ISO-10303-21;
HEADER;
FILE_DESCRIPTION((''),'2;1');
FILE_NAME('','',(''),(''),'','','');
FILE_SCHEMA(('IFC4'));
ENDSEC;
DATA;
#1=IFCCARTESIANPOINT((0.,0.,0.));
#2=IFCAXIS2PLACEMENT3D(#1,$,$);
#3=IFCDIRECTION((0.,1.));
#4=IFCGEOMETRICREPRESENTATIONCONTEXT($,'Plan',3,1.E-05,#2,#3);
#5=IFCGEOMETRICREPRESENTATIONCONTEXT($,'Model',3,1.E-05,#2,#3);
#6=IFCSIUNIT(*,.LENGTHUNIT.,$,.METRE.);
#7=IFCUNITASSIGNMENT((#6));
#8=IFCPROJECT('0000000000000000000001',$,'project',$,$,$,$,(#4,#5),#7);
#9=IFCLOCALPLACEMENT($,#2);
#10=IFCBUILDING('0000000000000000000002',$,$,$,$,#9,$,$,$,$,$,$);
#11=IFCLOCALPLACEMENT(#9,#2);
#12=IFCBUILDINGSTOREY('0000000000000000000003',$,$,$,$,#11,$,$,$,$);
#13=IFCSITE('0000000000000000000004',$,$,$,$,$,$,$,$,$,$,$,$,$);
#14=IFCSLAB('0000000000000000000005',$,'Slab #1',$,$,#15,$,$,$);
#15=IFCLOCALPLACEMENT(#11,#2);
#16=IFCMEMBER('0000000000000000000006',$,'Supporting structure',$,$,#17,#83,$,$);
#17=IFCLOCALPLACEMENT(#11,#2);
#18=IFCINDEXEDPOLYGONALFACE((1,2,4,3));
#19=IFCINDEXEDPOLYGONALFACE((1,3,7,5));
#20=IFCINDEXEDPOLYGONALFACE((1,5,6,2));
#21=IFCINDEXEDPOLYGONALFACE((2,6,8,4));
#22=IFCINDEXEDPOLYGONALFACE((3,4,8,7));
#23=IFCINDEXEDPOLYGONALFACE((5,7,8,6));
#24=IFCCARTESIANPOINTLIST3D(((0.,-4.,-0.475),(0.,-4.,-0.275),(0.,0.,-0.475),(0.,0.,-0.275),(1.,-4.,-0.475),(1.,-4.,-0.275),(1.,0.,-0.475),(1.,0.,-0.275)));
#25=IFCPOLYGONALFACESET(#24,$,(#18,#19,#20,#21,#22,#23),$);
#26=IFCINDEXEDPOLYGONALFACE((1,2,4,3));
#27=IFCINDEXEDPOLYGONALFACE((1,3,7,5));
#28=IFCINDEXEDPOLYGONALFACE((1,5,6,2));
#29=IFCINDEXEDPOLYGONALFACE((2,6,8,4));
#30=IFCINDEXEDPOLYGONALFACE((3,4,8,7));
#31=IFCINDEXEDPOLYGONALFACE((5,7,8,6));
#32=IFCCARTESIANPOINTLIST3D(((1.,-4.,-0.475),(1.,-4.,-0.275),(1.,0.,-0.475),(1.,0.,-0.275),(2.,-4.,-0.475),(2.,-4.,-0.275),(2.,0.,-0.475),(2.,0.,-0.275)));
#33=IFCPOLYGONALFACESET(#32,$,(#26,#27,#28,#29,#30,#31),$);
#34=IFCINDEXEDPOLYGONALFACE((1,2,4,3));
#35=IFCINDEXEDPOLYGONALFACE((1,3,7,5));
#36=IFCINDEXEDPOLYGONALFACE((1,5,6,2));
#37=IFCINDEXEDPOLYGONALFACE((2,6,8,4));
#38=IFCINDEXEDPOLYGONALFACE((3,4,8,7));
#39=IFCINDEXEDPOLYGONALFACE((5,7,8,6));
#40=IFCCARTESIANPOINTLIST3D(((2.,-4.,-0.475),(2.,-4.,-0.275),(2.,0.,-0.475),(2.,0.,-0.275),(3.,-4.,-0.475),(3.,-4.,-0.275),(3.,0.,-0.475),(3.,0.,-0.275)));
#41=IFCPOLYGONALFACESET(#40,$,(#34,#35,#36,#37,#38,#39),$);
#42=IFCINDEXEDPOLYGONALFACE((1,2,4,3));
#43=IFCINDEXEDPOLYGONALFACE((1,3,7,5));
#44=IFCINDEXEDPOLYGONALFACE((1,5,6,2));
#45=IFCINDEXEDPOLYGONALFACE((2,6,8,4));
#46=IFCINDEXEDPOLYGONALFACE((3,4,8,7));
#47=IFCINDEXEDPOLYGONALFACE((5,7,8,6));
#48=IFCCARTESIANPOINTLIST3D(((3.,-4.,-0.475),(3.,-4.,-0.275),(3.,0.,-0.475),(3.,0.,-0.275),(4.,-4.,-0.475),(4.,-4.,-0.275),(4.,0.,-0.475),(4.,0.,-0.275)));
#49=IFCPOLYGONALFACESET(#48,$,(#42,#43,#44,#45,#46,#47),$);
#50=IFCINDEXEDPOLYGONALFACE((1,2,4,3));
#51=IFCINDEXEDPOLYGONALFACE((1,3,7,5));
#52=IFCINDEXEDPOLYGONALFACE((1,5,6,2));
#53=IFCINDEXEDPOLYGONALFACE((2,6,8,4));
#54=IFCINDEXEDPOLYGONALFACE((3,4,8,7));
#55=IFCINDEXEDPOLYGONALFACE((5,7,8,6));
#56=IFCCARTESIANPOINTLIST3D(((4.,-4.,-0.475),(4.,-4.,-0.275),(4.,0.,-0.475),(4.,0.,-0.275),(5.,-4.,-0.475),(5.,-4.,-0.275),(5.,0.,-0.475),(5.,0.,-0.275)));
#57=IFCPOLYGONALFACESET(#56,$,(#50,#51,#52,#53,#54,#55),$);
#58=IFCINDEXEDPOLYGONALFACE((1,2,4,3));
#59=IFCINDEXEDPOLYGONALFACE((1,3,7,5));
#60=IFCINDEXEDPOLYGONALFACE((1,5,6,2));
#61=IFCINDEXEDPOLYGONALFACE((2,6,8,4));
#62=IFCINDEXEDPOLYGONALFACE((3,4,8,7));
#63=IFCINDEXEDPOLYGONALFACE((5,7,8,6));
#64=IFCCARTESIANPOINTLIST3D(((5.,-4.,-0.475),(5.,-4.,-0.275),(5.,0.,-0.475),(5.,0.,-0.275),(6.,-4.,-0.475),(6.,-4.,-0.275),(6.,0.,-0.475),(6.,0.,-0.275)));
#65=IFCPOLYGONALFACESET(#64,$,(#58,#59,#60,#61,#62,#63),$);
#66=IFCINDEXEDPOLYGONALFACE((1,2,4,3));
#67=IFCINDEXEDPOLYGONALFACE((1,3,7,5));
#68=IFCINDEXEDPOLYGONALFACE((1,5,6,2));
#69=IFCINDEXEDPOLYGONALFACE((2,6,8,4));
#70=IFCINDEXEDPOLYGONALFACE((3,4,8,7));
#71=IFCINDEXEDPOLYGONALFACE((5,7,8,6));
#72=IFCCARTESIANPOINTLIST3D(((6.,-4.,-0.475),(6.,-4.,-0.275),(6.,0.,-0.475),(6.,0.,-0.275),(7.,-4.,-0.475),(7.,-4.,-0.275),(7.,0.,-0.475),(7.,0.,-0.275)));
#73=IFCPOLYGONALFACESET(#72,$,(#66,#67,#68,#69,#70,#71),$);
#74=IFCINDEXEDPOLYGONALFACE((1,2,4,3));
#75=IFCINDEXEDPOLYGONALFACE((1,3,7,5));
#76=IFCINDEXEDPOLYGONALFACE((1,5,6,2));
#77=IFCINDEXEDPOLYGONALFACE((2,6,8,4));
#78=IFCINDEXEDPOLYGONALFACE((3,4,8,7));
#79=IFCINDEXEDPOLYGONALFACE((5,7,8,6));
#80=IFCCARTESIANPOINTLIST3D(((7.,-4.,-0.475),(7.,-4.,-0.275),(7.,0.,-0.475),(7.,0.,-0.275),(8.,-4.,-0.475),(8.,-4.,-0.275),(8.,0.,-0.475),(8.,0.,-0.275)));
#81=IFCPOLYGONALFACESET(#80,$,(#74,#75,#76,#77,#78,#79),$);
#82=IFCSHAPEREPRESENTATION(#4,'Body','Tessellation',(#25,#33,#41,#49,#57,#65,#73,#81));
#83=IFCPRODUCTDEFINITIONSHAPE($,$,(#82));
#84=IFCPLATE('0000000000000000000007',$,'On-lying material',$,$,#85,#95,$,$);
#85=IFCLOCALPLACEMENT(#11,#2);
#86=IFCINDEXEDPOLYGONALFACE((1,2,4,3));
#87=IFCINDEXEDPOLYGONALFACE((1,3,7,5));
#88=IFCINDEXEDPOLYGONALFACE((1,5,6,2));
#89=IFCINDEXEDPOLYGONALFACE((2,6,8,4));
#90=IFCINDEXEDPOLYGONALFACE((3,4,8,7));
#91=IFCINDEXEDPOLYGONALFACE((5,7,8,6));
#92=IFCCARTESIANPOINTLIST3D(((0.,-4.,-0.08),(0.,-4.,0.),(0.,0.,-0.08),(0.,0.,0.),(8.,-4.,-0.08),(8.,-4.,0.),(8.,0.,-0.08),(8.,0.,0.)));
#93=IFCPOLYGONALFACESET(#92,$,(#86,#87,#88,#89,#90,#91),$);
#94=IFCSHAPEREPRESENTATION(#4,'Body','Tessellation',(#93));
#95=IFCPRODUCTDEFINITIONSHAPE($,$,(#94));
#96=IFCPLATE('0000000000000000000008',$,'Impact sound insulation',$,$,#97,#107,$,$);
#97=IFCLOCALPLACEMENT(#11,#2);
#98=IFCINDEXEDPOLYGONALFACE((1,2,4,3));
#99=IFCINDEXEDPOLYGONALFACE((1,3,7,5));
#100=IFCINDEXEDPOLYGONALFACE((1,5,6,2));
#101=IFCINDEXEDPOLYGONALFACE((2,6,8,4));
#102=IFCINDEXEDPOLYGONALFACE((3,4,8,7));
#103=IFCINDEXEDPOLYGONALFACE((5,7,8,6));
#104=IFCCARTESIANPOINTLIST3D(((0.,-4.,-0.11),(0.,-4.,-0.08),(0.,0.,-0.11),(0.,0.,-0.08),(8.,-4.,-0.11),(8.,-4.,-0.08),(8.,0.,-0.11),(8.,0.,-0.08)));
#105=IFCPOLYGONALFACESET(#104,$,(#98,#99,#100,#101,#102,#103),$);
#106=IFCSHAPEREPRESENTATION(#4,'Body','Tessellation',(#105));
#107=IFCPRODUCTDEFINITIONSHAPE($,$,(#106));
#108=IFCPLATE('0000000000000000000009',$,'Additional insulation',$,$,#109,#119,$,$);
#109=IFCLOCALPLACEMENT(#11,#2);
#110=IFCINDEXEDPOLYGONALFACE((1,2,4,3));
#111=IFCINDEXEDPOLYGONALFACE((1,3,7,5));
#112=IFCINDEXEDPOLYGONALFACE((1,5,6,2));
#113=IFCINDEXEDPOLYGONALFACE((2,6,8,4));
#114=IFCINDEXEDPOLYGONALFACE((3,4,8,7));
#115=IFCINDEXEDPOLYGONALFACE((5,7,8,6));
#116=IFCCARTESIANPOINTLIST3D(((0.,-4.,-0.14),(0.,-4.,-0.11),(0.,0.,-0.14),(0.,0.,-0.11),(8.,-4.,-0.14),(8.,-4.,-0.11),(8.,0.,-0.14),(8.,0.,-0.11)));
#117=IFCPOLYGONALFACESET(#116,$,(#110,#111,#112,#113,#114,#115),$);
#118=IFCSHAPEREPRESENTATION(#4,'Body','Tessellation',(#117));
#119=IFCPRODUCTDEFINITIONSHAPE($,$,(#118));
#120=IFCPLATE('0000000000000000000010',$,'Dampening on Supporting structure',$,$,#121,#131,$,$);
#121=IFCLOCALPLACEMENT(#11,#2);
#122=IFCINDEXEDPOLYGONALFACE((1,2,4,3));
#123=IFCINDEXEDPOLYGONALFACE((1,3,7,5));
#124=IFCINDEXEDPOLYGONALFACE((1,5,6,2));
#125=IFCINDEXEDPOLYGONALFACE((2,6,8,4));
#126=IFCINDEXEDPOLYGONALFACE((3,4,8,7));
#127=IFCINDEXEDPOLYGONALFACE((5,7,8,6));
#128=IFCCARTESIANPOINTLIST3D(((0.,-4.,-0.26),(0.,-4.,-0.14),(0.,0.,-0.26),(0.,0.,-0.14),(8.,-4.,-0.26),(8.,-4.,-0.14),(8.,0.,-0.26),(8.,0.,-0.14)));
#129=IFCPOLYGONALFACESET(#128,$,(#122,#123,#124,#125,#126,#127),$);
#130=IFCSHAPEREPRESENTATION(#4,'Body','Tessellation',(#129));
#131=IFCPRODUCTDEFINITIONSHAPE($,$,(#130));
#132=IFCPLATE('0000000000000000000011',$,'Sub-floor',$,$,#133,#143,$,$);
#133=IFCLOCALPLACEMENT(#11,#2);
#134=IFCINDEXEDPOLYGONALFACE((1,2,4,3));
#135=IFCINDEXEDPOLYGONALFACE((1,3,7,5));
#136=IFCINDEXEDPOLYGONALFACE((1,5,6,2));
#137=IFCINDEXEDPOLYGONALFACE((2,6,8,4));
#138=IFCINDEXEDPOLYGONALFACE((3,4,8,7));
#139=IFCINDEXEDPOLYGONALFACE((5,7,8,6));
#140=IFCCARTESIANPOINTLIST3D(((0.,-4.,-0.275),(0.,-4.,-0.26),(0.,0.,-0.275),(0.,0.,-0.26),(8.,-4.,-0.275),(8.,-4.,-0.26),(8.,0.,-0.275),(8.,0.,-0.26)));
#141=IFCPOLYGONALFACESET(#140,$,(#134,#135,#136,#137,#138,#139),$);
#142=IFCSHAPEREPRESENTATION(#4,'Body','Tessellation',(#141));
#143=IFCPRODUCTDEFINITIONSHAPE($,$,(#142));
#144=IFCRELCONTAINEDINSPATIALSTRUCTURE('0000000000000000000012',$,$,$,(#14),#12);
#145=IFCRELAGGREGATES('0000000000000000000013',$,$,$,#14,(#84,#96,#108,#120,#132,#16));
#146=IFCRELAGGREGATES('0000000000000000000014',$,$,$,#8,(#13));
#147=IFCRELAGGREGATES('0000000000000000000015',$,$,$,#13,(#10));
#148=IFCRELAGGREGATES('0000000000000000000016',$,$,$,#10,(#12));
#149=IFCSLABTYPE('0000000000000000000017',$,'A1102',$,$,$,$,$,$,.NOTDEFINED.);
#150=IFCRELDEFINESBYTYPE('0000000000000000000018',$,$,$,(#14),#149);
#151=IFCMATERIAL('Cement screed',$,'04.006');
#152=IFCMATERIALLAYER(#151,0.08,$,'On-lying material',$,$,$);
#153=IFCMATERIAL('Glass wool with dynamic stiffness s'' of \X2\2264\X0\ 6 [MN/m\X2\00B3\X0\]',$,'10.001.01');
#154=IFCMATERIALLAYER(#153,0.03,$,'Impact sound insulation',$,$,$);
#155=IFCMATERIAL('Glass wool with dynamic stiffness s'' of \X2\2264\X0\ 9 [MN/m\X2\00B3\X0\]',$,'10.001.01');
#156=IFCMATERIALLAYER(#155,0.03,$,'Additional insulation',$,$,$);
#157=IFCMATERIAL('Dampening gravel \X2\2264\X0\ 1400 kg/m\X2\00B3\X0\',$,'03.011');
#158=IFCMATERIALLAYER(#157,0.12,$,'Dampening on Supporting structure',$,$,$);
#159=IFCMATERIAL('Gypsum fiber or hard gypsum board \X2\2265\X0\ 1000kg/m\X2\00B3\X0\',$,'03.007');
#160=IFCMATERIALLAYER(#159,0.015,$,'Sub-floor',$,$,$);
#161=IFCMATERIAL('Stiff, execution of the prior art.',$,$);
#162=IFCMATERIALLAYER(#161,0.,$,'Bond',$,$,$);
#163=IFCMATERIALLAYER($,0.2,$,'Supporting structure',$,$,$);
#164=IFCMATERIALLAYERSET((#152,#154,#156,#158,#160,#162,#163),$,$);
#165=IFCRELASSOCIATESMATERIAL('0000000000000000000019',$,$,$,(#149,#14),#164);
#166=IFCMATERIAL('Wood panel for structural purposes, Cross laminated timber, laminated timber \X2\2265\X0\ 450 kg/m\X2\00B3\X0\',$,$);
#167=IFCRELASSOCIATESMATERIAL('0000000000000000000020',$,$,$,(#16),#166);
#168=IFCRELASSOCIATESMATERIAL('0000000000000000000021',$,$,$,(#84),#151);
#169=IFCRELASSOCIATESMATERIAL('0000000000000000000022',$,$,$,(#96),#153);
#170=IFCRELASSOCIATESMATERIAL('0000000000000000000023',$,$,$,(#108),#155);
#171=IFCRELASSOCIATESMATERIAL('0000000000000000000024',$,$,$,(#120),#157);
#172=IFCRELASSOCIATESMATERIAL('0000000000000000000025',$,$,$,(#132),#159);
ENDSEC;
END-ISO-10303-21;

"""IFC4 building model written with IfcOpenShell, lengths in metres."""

from ifc_helpers import new_model, si_unit, direction, frame, frame_2d, origin, origin_with_axes, place, context, project, spatial, rectangle, extrude, material, layer, layer_set, type_object, element, aggregate, save


model = new_model("IFC4")

# Units and contexts
plan_context = context("Plan", 3, precision=1e-05, world=origin(), true_north=direction((0.0, 1.0)))
model_context = context("Model", 3, precision=1e-05, world=origin(), true_north=direction((0.0, 1.0)))
ifc_project = project(units=[si_unit("LENGTHUNIT", "METRE")], contexts=[plan_context, model_context])

# Site, building, storey
site = spatial("IfcSite", under=ifc_project)
building_placement = place(None, origin())
building = spatial("IfcBuilding", under=site, at=building_placement)
storey_placement = place(building_placement, origin())
storey = spatial("IfcBuildingStorey", under=building, at=storey_placement)

# Slab, member, plates
ifc_material_1 = material(Name="Cement screed", Category="04.006")
ifc_layer_1 = layer(ifc_material_1, 0.08, Name="On-lying material")
ifc_material_2 = material(Name="Glass wool with dynamic stiffness s' of ≤ 6 [MN/m³]", Category="10.001.01")
ifc_layer_2 = layer(ifc_material_2, 0.03, Name="Impact sound insulation")
ifc_material_3 = material(Name="Glass wool with dynamic stiffness s' of ≤ 9 [MN/m³]", Category="10.001.01")
ifc_layer_3 = layer(ifc_material_3, 0.03, Name="Additional insulation")
ifc_material_4 = material(Name="Dampening gravel ≤ 1400 kg/m³", Category="03.011")
ifc_layer_4 = layer(ifc_material_4, 0.12, Name="Dampening on Supporting structure")
ifc_material_5 = material(Name="Gypsum fiber or hard gypsum board ≥ 1000kg/m³", Category="03.007")
ifc_layer_5 = layer(ifc_material_5, 0.015, Name="Sub-floor")
ifc_material_6 = material(Name="Stiff, execution of the prior art.")
ifc_layer_6 = layer(ifc_material_6, 0.0, Name="Bond")
ifc_layer_7 = layer(None, 0.2, Name="Supporting structure")
ifc_layer_set = layer_set([ifc_layer_1, ifc_layer_2, ifc_layer_3, ifc_layer_4, ifc_layer_5, ifc_layer_6, ifc_layer_7])
slab_type = type_object("IfcSlabType", Name="A1102", PredefinedType="NOTDEFINED", material=ifc_layer_set)
slab_placement = place(None, frame((0.0, 0.0, 0.0), z_axis=(0.0, 0.0, -1.0), x_axis=(1.0, 0.0, 0.0)))
slab = element("IfcSlab", 1, at=slab_placement, inside=storey, type_object=slab_type, material=ifc_layer_set, Name="Slab #1")
ifc_material_7 = material(Name="Wood panel for structural purposes, Cross laminated timber, laminated timber ≥ 450 kg/m³")
member_placement = place(slab_placement, origin())
member = element("IfcMember", 2, at=member_placement, material=ifc_material_7, Name="Supporting structure", context=plan_context, shape_type="SweptSolid", body=[
    extrude(rectangle(XDim=1.0, YDim=0.2, at=frame_2d((0.5, 0.1), x_axis=(1.0, 0.0))), frame((0.0, 4.0, 0.275), z_axis=(0.0, -1.0, 0.0), x_axis=(1.0, 0.0, 0.0)), (0.0, 0.0, 1.0), 4.0),
    extrude(rectangle(XDim=1.0, YDim=0.2, at=frame_2d((0.5, 0.1), x_axis=(1.0, 0.0))), frame((1.0, 4.0, 0.275), z_axis=(0.0, -1.0, 0.0), x_axis=(1.0, 0.0, 0.0)), (0.0, 0.0, 1.0), 4.0),
    extrude(rectangle(XDim=1.0, YDim=0.2, at=frame_2d((0.5, 0.1), x_axis=(1.0, 0.0))), frame((2.0, 4.0, 0.275), z_axis=(0.0, -1.0, 0.0), x_axis=(1.0, 0.0, 0.0)), (0.0, 0.0, 1.0), 4.0),
    extrude(rectangle(XDim=1.0, YDim=0.2, at=frame_2d((0.5, 0.1), x_axis=(1.0, 0.0))), frame((3.0, 4.0, 0.275), z_axis=(0.0, -1.0, 0.0), x_axis=(1.0, 0.0, 0.0)), (0.0, 0.0, 1.0), 4.0),
    extrude(rectangle(XDim=1.0, YDim=0.2, at=frame_2d((0.5, 0.1), x_axis=(1.0, 0.0))), frame((4.0, 4.0, 0.275), z_axis=(0.0, -1.0, 0.0), x_axis=(1.0, 0.0, 0.0)), (0.0, 0.0, 1.0), 4.0),
    extrude(rectangle(XDim=1.0, YDim=0.2, at=frame_2d((0.5, 0.1), x_axis=(1.0, 0.0))), frame((5.0, 4.0, 0.275), z_axis=(0.0, -1.0, 0.0), x_axis=(1.0, 0.0, 0.0)), (0.0, 0.0, 1.0), 4.0),
    extrude(rectangle(XDim=1.0, YDim=0.2, at=frame_2d((0.5, 0.1), x_axis=(1.0, 0.0))), frame((6.0, 4.0, 0.275), z_axis=(0.0, -1.0, 0.0), x_axis=(1.0, 0.0, 0.0)), (0.0, 0.0, 1.0), 4.0),
    extrude(rectangle(XDim=1.0, YDim=0.2, at=frame_2d((0.5, 0.1), x_axis=(1.0, 0.0))), frame((7.0, 4.0, 0.275), z_axis=(0.0, -1.0, 0.0), x_axis=(1.0, 0.0, 0.0)), (0.0, 0.0, 1.0), 4.0),
])
plate_1_placement = place(slab_placement, origin())
plate_1 = element("IfcPlate", 3, at=plate_1_placement, material=ifc_material_1, Name="On-lying material", context=plan_context, shape_type="SweptSolid", body=[
    extrude(rectangle(XDim=8.0, YDim=4.0, at=frame_2d((4.0, 2.0), x_axis=(1.0, 0.0))), origin_with_axes(), (0.0, 0.0, 1.0), 0.08),
])
plate_2_placement = place(slab_placement, origin())
plate_2 = element("IfcPlate", 4, at=plate_2_placement, material=ifc_material_2, Name="Impact sound insulation", context=plan_context, shape_type="SweptSolid", body=[
    extrude(rectangle(XDim=8.0, YDim=4.0, at=frame_2d((4.0, 2.0), x_axis=(1.0, 0.0))), frame((0.0, 0.0, 0.08), z_axis=(0.0, 0.0, 1.0), x_axis=(1.0, 0.0, 0.0)), (0.0, 0.0, 1.0), 0.03),
])
plate_3_placement = place(slab_placement, origin())
plate_3 = element("IfcPlate", 5, at=plate_3_placement, material=ifc_material_3, Name="Additional insulation", context=plan_context, shape_type="SweptSolid", body=[
    extrude(rectangle(XDim=8.0, YDim=4.0, at=frame_2d((4.0, 2.0), x_axis=(1.0, 0.0))), frame((0.0, 0.0, 0.11), z_axis=(0.0, 0.0, 1.0), x_axis=(1.0, 0.0, 0.0)), (0.0, 0.0, 1.0), 0.03),
])
plate_4_placement = place(slab_placement, origin())
plate_4 = element("IfcPlate", 6, at=plate_4_placement, material=ifc_material_4, Name="Dampening on Supporting structure", context=plan_context, shape_type="SweptSolid", body=[
    extrude(rectangle(XDim=8.0, YDim=4.0, at=frame_2d((4.0, 2.0), x_axis=(1.0, 0.0))), frame((0.0, 0.0, 0.14), z_axis=(0.0, 0.0, 1.0), x_axis=(1.0, 0.0, 0.0)), (0.0, 0.0, 1.0), 0.12),
])
plate_5_placement = place(slab_placement, origin())
plate_5 = element("IfcPlate", 7, at=plate_5_placement, material=ifc_material_5, Name="Sub-floor", context=plan_context, shape_type="SweptSolid", body=[
    extrude(rectangle(XDim=8.0, YDim=4.0, at=frame_2d((4.0, 2.0), x_axis=(1.0, 0.0))), frame((0.0, 0.0, 0.26), z_axis=(0.0, 0.0, 1.0), x_axis=(1.0, 0.0, 0.0)), (0.0, 0.0, 1.0), 0.015),
])
aggregate(slab, [plate_1, plate_2, plate_3, plate_4, plate_5, member])

save(model, "model.ifc")
